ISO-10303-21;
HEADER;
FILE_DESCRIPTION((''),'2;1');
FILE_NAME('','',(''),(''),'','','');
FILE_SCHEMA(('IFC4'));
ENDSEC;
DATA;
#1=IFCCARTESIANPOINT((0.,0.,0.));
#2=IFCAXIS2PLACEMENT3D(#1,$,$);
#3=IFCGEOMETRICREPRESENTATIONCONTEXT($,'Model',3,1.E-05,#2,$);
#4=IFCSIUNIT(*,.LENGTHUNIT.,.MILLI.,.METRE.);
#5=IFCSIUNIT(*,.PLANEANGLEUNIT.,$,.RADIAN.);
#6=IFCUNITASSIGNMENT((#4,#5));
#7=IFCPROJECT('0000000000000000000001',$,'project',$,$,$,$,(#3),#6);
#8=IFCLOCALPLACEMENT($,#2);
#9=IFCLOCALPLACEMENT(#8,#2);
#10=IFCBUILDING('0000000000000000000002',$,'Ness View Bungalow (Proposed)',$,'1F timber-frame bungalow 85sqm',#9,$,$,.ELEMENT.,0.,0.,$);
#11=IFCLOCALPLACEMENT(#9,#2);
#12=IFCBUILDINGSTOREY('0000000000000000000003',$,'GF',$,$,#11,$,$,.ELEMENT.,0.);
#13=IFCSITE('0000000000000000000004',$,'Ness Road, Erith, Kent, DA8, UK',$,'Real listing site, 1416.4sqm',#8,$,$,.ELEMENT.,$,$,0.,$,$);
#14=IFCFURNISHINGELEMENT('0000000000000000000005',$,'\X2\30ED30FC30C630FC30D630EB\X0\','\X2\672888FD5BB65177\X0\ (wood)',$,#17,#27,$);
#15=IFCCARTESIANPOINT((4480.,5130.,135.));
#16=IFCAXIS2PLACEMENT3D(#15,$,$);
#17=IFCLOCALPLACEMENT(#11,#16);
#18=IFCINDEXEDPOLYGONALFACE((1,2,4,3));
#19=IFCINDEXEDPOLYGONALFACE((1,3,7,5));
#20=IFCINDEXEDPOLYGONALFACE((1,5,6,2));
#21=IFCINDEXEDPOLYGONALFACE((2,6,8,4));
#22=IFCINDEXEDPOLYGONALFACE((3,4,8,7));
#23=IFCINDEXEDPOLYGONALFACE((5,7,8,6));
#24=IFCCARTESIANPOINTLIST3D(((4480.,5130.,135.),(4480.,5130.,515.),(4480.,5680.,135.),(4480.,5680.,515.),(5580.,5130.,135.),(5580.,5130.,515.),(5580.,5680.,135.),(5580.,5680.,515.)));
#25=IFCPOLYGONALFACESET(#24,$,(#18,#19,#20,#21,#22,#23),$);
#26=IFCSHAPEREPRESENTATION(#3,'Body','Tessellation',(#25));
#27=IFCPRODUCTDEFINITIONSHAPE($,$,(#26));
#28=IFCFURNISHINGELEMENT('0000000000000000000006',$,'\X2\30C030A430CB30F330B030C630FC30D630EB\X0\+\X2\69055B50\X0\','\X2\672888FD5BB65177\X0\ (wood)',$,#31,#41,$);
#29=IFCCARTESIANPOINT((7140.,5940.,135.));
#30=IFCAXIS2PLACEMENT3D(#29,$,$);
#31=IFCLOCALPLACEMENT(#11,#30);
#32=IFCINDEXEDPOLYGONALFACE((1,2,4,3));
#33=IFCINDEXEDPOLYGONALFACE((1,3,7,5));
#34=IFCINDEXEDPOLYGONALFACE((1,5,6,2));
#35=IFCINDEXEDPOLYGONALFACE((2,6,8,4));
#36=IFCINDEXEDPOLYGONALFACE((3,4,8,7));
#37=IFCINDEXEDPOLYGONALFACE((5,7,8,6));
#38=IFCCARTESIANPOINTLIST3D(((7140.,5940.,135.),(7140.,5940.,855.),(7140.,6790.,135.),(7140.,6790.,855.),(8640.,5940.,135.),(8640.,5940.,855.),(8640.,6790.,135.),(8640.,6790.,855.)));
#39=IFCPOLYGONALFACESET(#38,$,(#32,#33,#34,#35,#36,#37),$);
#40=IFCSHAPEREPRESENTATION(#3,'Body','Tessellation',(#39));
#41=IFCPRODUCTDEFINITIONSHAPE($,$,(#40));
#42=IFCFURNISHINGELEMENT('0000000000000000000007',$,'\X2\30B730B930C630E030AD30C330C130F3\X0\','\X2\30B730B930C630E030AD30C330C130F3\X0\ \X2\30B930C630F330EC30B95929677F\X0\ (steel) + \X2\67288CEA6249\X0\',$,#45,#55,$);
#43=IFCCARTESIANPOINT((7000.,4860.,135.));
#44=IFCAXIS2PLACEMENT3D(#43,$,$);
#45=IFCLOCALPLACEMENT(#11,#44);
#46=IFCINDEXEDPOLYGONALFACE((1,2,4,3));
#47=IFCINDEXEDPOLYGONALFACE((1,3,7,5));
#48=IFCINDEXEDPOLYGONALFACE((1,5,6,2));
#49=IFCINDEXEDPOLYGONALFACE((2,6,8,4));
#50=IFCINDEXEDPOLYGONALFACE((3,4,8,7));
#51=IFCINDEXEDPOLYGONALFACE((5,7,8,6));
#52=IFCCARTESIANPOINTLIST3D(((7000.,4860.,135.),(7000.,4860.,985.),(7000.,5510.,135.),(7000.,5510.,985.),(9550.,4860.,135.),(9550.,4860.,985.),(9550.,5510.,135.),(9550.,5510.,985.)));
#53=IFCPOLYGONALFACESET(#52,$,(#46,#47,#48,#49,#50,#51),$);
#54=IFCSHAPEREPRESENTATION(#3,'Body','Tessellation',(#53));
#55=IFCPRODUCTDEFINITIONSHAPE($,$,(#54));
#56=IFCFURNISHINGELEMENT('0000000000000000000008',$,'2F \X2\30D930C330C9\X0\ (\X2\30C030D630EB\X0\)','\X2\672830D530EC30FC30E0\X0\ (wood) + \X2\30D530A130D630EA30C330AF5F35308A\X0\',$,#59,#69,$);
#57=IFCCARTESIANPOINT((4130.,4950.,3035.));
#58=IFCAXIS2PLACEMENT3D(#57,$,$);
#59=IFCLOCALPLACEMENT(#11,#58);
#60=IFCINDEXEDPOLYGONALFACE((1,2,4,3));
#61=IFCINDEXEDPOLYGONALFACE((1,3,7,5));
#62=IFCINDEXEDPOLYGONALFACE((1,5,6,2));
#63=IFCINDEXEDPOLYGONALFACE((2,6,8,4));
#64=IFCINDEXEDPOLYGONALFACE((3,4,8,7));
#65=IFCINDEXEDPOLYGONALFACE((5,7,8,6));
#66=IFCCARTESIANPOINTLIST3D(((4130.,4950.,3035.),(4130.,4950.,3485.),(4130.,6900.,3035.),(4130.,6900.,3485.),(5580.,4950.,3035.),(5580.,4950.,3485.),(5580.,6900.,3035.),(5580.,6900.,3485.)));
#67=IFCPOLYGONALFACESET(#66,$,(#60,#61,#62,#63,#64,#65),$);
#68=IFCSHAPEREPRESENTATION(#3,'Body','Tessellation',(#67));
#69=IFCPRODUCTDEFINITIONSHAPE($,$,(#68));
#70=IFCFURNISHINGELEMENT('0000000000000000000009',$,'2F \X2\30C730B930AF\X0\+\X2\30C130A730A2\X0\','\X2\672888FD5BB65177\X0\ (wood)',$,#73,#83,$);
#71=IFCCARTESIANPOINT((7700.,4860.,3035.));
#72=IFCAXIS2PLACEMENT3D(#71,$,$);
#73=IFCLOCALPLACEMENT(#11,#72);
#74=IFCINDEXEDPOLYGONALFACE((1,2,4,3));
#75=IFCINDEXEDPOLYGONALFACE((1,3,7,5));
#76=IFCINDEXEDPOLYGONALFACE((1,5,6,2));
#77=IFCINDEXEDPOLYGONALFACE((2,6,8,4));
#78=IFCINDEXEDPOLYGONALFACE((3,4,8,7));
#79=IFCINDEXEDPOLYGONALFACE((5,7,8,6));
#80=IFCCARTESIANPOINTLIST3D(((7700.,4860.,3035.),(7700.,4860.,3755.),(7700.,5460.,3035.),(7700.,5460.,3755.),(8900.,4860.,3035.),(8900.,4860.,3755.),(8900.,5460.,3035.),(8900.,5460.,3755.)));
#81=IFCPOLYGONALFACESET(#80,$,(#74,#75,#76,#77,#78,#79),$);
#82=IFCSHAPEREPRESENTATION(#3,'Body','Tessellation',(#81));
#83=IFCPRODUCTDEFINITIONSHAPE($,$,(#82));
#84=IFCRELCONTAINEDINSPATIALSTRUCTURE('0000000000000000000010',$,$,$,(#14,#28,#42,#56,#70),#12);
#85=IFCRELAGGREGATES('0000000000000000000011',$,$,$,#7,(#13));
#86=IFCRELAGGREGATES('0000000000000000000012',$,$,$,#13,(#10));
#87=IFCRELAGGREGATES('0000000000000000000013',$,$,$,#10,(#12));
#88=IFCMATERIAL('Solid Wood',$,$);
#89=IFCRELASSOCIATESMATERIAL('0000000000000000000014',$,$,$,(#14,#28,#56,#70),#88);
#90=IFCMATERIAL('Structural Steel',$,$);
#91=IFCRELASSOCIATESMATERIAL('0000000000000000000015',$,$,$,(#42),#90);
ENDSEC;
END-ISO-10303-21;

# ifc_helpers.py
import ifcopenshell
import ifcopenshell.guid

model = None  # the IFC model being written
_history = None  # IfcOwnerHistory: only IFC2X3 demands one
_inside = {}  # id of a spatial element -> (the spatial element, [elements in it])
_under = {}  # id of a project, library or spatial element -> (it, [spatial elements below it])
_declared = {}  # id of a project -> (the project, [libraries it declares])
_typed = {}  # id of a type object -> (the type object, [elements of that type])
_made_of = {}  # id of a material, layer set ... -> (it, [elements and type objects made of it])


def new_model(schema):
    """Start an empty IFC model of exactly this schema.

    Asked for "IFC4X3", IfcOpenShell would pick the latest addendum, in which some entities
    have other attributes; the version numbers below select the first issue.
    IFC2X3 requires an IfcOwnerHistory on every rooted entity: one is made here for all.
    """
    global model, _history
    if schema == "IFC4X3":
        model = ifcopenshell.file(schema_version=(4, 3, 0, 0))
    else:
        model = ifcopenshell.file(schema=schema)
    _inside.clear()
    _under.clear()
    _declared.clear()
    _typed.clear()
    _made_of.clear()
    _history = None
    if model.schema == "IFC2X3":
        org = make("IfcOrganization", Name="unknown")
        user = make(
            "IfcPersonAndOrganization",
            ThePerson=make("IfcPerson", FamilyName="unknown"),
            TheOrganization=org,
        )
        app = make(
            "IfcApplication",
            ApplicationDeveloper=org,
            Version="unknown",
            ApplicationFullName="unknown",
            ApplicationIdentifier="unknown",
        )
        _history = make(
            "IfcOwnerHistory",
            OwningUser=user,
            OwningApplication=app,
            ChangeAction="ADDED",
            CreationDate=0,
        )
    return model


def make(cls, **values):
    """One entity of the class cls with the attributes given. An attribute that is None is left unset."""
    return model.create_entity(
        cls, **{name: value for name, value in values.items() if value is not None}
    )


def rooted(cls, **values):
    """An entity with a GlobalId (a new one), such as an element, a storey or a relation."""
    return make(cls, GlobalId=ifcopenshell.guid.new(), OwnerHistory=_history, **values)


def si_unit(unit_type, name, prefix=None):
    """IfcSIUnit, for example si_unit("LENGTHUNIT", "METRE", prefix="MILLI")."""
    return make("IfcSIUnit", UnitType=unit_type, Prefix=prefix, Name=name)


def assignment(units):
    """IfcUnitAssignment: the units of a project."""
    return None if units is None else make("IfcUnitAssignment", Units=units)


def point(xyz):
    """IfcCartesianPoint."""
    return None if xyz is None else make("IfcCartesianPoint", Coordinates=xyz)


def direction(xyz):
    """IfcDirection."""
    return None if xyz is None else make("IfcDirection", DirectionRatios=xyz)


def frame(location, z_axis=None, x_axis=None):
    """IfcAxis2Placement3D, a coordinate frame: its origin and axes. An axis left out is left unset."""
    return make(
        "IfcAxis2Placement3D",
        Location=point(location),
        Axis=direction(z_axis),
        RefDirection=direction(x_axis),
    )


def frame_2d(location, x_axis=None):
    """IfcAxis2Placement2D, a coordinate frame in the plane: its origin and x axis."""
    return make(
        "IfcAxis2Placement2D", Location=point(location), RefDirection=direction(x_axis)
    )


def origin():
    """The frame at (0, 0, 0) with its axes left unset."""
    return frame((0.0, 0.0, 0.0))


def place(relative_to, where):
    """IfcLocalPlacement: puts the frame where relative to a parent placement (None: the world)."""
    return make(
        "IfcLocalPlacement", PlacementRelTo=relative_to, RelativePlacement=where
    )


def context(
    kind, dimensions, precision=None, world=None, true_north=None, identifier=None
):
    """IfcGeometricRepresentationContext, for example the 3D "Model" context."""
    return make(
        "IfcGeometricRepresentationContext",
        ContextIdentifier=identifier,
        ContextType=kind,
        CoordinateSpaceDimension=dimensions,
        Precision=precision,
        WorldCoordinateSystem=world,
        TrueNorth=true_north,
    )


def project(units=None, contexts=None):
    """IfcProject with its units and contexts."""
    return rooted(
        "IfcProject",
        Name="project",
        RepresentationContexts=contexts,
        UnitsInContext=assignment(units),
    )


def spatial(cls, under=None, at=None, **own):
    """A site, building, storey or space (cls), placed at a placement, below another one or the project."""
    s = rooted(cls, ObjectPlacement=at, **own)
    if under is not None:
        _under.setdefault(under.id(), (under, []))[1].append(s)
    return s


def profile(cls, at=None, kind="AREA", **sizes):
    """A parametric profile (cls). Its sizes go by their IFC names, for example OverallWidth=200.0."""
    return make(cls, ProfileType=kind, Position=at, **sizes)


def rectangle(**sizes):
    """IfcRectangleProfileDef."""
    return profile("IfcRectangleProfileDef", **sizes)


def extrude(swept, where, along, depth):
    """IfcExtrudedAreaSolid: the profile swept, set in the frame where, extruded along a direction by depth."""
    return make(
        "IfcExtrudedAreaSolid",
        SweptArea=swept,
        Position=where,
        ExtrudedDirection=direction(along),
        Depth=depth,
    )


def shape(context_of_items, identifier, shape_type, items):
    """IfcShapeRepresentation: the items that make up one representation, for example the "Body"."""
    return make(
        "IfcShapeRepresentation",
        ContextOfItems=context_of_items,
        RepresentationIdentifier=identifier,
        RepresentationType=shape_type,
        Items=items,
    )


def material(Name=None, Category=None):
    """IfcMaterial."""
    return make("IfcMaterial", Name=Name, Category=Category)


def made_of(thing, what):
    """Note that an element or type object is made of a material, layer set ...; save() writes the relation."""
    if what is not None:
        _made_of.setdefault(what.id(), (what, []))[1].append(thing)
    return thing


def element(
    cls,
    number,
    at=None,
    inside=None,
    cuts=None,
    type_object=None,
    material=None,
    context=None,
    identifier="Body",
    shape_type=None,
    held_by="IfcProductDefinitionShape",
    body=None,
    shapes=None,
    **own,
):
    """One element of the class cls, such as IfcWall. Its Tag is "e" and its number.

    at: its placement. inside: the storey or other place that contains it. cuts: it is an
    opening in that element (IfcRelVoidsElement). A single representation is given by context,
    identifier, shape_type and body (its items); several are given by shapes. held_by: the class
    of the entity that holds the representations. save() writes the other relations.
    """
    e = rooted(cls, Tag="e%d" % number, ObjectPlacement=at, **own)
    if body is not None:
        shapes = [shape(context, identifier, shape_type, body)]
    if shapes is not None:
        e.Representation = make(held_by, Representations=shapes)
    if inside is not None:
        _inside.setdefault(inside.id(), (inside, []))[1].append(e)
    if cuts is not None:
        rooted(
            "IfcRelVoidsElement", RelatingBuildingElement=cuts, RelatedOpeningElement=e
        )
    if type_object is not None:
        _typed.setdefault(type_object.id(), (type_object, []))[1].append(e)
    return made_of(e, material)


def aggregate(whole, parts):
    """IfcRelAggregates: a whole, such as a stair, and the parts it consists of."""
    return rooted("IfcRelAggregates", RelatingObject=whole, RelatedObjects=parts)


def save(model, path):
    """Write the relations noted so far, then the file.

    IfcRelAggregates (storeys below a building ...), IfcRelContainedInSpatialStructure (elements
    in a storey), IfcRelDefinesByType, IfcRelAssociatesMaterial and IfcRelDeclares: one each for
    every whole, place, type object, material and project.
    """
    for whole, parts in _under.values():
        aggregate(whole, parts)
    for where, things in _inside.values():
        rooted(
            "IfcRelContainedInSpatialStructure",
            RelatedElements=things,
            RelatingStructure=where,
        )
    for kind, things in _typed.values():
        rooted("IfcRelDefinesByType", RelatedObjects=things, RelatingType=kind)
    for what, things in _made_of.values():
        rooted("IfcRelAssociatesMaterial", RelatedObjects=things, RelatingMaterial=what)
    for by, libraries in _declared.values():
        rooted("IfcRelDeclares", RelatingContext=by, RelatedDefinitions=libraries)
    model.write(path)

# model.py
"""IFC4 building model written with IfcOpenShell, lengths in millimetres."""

from ifc_helpers import new_model, si_unit, frame, frame_2d, origin, place, context, project, spatial, rectangle, extrude, material, element, save


model = new_model("IFC4")

# Units and contexts
model_context = context("Model", 3, precision=1e-05, world=origin())
ifc_project = project(units=[si_unit("LENGTHUNIT", "METRE", prefix="MILLI"), si_unit("PLANEANGLEUNIT", "RADIAN")], contexts=[model_context])

# Site, building, storey
site_placement = place(None, origin())
site = spatial("IfcSite", under=ifc_project, at=site_placement, Name="Ness Road, Erith, Kent, DA8, UK", ObjectType="Real listing site, 1416.4sqm", CompositionType="ELEMENT", RefElevation=0.0)
building_placement = place(site_placement, origin())
building = spatial("IfcBuilding", under=site, at=building_placement, Name="Ness View Bungalow (Proposed)", ObjectType="1F timber-frame bungalow 85sqm", CompositionType="ELEMENT", ElevationOfRefHeight=0.0, ElevationOfTerrain=0.0)
storey_placement = place(building_placement, origin())
storey = spatial("IfcBuildingStorey", under=building, at=storey_placement, Name="GF", CompositionType="ELEMENT", Elevation=0.0)

# Shared definitions
ifc_material_1 = material(Name="Solid Wood")

# Shared definitions
ifc_material_2 = material(Name="Structural Steel")

# Furnishing elements
furnishing_1_placement = place(storey_placement, frame((4480.0, 5130.0, 135.0)))
element("IfcFurnishingElement", 1, at=furnishing_1_placement, inside=storey, material=ifc_material_1, Name="ローテーブル", Description="木製家具 (wood)", context=model_context, shape_type="SweptSolid", body=[
    extrude(rectangle(XDim=1100.0, YDim=550.0, at=frame_2d((550.0, 275.0))), frame((4480.0, 5130.0, 135.0)), (0.0, 0.0, 1.0), 380.0),
])
furnishing_2_placement = place(storey_placement, frame((7140.0, 5940.0, 135.0)))
element("IfcFurnishingElement", 2, at=furnishing_2_placement, inside=storey, material=ifc_material_1, Name="ダイニングテーブル+椅子", Description="木製家具 (wood)", context=model_context, shape_type="SweptSolid", body=[
    extrude(rectangle(XDim=1500.0, YDim=850.0, at=frame_2d((750.0, 425.0))), frame((7140.0, 5940.0, 135.0)), (0.0, 0.0, 1.0), 720.0),
])
furnishing_3_placement = place(storey_placement, frame((7000.0, 4860.0, 135.0)))
element("IfcFurnishingElement", 3, at=furnishing_3_placement, inside=storey, material=ifc_material_2, Name="システムキッチン", Description="システムキッチン ステンレス天板 (steel) + 木質扉", context=model_context, shape_type="SweptSolid", body=[
    extrude(rectangle(XDim=2550.0, YDim=650.0, at=frame_2d((1275.0, 325.0))), frame((7000.0, 4860.0, 135.0)), (0.0, 0.0, 1.0), 850.0),
])
furnishing_4_placement = place(storey_placement, frame((4130.0, 4950.0, 3035.0)))
element("IfcFurnishingElement", 4, at=furnishing_4_placement, inside=storey, material=ifc_material_1, Name="2F ベッド (ダブル)", Description="木フレーム (wood) + ファブリック張り", context=model_context, shape_type="SweptSolid", body=[
    extrude(rectangle(XDim=1450.0, YDim=1950.0, at=frame_2d((725.0, 975.0))), frame((4130.0, 4950.0, 3035.0)), (0.0, 0.0, 1.0), 450.0),
])
furnishing_5_placement = place(storey_placement, frame((7700.0, 4860.0, 3035.0)))
element("IfcFurnishingElement", 5, at=furnishing_5_placement, inside=storey, material=ifc_material_1, Name="2F デスク+チェア", Description="木製家具 (wood)", context=model_context, shape_type="SweptSolid", body=[
    extrude(rectangle(XDim=1200.0, YDim=600.0, at=frame_2d((600.0, 300.0))), frame((7700.0, 4860.0, 3035.0)), (0.0, 0.0, 1.0), 720.0),
])

save(model, "model.ifc")
